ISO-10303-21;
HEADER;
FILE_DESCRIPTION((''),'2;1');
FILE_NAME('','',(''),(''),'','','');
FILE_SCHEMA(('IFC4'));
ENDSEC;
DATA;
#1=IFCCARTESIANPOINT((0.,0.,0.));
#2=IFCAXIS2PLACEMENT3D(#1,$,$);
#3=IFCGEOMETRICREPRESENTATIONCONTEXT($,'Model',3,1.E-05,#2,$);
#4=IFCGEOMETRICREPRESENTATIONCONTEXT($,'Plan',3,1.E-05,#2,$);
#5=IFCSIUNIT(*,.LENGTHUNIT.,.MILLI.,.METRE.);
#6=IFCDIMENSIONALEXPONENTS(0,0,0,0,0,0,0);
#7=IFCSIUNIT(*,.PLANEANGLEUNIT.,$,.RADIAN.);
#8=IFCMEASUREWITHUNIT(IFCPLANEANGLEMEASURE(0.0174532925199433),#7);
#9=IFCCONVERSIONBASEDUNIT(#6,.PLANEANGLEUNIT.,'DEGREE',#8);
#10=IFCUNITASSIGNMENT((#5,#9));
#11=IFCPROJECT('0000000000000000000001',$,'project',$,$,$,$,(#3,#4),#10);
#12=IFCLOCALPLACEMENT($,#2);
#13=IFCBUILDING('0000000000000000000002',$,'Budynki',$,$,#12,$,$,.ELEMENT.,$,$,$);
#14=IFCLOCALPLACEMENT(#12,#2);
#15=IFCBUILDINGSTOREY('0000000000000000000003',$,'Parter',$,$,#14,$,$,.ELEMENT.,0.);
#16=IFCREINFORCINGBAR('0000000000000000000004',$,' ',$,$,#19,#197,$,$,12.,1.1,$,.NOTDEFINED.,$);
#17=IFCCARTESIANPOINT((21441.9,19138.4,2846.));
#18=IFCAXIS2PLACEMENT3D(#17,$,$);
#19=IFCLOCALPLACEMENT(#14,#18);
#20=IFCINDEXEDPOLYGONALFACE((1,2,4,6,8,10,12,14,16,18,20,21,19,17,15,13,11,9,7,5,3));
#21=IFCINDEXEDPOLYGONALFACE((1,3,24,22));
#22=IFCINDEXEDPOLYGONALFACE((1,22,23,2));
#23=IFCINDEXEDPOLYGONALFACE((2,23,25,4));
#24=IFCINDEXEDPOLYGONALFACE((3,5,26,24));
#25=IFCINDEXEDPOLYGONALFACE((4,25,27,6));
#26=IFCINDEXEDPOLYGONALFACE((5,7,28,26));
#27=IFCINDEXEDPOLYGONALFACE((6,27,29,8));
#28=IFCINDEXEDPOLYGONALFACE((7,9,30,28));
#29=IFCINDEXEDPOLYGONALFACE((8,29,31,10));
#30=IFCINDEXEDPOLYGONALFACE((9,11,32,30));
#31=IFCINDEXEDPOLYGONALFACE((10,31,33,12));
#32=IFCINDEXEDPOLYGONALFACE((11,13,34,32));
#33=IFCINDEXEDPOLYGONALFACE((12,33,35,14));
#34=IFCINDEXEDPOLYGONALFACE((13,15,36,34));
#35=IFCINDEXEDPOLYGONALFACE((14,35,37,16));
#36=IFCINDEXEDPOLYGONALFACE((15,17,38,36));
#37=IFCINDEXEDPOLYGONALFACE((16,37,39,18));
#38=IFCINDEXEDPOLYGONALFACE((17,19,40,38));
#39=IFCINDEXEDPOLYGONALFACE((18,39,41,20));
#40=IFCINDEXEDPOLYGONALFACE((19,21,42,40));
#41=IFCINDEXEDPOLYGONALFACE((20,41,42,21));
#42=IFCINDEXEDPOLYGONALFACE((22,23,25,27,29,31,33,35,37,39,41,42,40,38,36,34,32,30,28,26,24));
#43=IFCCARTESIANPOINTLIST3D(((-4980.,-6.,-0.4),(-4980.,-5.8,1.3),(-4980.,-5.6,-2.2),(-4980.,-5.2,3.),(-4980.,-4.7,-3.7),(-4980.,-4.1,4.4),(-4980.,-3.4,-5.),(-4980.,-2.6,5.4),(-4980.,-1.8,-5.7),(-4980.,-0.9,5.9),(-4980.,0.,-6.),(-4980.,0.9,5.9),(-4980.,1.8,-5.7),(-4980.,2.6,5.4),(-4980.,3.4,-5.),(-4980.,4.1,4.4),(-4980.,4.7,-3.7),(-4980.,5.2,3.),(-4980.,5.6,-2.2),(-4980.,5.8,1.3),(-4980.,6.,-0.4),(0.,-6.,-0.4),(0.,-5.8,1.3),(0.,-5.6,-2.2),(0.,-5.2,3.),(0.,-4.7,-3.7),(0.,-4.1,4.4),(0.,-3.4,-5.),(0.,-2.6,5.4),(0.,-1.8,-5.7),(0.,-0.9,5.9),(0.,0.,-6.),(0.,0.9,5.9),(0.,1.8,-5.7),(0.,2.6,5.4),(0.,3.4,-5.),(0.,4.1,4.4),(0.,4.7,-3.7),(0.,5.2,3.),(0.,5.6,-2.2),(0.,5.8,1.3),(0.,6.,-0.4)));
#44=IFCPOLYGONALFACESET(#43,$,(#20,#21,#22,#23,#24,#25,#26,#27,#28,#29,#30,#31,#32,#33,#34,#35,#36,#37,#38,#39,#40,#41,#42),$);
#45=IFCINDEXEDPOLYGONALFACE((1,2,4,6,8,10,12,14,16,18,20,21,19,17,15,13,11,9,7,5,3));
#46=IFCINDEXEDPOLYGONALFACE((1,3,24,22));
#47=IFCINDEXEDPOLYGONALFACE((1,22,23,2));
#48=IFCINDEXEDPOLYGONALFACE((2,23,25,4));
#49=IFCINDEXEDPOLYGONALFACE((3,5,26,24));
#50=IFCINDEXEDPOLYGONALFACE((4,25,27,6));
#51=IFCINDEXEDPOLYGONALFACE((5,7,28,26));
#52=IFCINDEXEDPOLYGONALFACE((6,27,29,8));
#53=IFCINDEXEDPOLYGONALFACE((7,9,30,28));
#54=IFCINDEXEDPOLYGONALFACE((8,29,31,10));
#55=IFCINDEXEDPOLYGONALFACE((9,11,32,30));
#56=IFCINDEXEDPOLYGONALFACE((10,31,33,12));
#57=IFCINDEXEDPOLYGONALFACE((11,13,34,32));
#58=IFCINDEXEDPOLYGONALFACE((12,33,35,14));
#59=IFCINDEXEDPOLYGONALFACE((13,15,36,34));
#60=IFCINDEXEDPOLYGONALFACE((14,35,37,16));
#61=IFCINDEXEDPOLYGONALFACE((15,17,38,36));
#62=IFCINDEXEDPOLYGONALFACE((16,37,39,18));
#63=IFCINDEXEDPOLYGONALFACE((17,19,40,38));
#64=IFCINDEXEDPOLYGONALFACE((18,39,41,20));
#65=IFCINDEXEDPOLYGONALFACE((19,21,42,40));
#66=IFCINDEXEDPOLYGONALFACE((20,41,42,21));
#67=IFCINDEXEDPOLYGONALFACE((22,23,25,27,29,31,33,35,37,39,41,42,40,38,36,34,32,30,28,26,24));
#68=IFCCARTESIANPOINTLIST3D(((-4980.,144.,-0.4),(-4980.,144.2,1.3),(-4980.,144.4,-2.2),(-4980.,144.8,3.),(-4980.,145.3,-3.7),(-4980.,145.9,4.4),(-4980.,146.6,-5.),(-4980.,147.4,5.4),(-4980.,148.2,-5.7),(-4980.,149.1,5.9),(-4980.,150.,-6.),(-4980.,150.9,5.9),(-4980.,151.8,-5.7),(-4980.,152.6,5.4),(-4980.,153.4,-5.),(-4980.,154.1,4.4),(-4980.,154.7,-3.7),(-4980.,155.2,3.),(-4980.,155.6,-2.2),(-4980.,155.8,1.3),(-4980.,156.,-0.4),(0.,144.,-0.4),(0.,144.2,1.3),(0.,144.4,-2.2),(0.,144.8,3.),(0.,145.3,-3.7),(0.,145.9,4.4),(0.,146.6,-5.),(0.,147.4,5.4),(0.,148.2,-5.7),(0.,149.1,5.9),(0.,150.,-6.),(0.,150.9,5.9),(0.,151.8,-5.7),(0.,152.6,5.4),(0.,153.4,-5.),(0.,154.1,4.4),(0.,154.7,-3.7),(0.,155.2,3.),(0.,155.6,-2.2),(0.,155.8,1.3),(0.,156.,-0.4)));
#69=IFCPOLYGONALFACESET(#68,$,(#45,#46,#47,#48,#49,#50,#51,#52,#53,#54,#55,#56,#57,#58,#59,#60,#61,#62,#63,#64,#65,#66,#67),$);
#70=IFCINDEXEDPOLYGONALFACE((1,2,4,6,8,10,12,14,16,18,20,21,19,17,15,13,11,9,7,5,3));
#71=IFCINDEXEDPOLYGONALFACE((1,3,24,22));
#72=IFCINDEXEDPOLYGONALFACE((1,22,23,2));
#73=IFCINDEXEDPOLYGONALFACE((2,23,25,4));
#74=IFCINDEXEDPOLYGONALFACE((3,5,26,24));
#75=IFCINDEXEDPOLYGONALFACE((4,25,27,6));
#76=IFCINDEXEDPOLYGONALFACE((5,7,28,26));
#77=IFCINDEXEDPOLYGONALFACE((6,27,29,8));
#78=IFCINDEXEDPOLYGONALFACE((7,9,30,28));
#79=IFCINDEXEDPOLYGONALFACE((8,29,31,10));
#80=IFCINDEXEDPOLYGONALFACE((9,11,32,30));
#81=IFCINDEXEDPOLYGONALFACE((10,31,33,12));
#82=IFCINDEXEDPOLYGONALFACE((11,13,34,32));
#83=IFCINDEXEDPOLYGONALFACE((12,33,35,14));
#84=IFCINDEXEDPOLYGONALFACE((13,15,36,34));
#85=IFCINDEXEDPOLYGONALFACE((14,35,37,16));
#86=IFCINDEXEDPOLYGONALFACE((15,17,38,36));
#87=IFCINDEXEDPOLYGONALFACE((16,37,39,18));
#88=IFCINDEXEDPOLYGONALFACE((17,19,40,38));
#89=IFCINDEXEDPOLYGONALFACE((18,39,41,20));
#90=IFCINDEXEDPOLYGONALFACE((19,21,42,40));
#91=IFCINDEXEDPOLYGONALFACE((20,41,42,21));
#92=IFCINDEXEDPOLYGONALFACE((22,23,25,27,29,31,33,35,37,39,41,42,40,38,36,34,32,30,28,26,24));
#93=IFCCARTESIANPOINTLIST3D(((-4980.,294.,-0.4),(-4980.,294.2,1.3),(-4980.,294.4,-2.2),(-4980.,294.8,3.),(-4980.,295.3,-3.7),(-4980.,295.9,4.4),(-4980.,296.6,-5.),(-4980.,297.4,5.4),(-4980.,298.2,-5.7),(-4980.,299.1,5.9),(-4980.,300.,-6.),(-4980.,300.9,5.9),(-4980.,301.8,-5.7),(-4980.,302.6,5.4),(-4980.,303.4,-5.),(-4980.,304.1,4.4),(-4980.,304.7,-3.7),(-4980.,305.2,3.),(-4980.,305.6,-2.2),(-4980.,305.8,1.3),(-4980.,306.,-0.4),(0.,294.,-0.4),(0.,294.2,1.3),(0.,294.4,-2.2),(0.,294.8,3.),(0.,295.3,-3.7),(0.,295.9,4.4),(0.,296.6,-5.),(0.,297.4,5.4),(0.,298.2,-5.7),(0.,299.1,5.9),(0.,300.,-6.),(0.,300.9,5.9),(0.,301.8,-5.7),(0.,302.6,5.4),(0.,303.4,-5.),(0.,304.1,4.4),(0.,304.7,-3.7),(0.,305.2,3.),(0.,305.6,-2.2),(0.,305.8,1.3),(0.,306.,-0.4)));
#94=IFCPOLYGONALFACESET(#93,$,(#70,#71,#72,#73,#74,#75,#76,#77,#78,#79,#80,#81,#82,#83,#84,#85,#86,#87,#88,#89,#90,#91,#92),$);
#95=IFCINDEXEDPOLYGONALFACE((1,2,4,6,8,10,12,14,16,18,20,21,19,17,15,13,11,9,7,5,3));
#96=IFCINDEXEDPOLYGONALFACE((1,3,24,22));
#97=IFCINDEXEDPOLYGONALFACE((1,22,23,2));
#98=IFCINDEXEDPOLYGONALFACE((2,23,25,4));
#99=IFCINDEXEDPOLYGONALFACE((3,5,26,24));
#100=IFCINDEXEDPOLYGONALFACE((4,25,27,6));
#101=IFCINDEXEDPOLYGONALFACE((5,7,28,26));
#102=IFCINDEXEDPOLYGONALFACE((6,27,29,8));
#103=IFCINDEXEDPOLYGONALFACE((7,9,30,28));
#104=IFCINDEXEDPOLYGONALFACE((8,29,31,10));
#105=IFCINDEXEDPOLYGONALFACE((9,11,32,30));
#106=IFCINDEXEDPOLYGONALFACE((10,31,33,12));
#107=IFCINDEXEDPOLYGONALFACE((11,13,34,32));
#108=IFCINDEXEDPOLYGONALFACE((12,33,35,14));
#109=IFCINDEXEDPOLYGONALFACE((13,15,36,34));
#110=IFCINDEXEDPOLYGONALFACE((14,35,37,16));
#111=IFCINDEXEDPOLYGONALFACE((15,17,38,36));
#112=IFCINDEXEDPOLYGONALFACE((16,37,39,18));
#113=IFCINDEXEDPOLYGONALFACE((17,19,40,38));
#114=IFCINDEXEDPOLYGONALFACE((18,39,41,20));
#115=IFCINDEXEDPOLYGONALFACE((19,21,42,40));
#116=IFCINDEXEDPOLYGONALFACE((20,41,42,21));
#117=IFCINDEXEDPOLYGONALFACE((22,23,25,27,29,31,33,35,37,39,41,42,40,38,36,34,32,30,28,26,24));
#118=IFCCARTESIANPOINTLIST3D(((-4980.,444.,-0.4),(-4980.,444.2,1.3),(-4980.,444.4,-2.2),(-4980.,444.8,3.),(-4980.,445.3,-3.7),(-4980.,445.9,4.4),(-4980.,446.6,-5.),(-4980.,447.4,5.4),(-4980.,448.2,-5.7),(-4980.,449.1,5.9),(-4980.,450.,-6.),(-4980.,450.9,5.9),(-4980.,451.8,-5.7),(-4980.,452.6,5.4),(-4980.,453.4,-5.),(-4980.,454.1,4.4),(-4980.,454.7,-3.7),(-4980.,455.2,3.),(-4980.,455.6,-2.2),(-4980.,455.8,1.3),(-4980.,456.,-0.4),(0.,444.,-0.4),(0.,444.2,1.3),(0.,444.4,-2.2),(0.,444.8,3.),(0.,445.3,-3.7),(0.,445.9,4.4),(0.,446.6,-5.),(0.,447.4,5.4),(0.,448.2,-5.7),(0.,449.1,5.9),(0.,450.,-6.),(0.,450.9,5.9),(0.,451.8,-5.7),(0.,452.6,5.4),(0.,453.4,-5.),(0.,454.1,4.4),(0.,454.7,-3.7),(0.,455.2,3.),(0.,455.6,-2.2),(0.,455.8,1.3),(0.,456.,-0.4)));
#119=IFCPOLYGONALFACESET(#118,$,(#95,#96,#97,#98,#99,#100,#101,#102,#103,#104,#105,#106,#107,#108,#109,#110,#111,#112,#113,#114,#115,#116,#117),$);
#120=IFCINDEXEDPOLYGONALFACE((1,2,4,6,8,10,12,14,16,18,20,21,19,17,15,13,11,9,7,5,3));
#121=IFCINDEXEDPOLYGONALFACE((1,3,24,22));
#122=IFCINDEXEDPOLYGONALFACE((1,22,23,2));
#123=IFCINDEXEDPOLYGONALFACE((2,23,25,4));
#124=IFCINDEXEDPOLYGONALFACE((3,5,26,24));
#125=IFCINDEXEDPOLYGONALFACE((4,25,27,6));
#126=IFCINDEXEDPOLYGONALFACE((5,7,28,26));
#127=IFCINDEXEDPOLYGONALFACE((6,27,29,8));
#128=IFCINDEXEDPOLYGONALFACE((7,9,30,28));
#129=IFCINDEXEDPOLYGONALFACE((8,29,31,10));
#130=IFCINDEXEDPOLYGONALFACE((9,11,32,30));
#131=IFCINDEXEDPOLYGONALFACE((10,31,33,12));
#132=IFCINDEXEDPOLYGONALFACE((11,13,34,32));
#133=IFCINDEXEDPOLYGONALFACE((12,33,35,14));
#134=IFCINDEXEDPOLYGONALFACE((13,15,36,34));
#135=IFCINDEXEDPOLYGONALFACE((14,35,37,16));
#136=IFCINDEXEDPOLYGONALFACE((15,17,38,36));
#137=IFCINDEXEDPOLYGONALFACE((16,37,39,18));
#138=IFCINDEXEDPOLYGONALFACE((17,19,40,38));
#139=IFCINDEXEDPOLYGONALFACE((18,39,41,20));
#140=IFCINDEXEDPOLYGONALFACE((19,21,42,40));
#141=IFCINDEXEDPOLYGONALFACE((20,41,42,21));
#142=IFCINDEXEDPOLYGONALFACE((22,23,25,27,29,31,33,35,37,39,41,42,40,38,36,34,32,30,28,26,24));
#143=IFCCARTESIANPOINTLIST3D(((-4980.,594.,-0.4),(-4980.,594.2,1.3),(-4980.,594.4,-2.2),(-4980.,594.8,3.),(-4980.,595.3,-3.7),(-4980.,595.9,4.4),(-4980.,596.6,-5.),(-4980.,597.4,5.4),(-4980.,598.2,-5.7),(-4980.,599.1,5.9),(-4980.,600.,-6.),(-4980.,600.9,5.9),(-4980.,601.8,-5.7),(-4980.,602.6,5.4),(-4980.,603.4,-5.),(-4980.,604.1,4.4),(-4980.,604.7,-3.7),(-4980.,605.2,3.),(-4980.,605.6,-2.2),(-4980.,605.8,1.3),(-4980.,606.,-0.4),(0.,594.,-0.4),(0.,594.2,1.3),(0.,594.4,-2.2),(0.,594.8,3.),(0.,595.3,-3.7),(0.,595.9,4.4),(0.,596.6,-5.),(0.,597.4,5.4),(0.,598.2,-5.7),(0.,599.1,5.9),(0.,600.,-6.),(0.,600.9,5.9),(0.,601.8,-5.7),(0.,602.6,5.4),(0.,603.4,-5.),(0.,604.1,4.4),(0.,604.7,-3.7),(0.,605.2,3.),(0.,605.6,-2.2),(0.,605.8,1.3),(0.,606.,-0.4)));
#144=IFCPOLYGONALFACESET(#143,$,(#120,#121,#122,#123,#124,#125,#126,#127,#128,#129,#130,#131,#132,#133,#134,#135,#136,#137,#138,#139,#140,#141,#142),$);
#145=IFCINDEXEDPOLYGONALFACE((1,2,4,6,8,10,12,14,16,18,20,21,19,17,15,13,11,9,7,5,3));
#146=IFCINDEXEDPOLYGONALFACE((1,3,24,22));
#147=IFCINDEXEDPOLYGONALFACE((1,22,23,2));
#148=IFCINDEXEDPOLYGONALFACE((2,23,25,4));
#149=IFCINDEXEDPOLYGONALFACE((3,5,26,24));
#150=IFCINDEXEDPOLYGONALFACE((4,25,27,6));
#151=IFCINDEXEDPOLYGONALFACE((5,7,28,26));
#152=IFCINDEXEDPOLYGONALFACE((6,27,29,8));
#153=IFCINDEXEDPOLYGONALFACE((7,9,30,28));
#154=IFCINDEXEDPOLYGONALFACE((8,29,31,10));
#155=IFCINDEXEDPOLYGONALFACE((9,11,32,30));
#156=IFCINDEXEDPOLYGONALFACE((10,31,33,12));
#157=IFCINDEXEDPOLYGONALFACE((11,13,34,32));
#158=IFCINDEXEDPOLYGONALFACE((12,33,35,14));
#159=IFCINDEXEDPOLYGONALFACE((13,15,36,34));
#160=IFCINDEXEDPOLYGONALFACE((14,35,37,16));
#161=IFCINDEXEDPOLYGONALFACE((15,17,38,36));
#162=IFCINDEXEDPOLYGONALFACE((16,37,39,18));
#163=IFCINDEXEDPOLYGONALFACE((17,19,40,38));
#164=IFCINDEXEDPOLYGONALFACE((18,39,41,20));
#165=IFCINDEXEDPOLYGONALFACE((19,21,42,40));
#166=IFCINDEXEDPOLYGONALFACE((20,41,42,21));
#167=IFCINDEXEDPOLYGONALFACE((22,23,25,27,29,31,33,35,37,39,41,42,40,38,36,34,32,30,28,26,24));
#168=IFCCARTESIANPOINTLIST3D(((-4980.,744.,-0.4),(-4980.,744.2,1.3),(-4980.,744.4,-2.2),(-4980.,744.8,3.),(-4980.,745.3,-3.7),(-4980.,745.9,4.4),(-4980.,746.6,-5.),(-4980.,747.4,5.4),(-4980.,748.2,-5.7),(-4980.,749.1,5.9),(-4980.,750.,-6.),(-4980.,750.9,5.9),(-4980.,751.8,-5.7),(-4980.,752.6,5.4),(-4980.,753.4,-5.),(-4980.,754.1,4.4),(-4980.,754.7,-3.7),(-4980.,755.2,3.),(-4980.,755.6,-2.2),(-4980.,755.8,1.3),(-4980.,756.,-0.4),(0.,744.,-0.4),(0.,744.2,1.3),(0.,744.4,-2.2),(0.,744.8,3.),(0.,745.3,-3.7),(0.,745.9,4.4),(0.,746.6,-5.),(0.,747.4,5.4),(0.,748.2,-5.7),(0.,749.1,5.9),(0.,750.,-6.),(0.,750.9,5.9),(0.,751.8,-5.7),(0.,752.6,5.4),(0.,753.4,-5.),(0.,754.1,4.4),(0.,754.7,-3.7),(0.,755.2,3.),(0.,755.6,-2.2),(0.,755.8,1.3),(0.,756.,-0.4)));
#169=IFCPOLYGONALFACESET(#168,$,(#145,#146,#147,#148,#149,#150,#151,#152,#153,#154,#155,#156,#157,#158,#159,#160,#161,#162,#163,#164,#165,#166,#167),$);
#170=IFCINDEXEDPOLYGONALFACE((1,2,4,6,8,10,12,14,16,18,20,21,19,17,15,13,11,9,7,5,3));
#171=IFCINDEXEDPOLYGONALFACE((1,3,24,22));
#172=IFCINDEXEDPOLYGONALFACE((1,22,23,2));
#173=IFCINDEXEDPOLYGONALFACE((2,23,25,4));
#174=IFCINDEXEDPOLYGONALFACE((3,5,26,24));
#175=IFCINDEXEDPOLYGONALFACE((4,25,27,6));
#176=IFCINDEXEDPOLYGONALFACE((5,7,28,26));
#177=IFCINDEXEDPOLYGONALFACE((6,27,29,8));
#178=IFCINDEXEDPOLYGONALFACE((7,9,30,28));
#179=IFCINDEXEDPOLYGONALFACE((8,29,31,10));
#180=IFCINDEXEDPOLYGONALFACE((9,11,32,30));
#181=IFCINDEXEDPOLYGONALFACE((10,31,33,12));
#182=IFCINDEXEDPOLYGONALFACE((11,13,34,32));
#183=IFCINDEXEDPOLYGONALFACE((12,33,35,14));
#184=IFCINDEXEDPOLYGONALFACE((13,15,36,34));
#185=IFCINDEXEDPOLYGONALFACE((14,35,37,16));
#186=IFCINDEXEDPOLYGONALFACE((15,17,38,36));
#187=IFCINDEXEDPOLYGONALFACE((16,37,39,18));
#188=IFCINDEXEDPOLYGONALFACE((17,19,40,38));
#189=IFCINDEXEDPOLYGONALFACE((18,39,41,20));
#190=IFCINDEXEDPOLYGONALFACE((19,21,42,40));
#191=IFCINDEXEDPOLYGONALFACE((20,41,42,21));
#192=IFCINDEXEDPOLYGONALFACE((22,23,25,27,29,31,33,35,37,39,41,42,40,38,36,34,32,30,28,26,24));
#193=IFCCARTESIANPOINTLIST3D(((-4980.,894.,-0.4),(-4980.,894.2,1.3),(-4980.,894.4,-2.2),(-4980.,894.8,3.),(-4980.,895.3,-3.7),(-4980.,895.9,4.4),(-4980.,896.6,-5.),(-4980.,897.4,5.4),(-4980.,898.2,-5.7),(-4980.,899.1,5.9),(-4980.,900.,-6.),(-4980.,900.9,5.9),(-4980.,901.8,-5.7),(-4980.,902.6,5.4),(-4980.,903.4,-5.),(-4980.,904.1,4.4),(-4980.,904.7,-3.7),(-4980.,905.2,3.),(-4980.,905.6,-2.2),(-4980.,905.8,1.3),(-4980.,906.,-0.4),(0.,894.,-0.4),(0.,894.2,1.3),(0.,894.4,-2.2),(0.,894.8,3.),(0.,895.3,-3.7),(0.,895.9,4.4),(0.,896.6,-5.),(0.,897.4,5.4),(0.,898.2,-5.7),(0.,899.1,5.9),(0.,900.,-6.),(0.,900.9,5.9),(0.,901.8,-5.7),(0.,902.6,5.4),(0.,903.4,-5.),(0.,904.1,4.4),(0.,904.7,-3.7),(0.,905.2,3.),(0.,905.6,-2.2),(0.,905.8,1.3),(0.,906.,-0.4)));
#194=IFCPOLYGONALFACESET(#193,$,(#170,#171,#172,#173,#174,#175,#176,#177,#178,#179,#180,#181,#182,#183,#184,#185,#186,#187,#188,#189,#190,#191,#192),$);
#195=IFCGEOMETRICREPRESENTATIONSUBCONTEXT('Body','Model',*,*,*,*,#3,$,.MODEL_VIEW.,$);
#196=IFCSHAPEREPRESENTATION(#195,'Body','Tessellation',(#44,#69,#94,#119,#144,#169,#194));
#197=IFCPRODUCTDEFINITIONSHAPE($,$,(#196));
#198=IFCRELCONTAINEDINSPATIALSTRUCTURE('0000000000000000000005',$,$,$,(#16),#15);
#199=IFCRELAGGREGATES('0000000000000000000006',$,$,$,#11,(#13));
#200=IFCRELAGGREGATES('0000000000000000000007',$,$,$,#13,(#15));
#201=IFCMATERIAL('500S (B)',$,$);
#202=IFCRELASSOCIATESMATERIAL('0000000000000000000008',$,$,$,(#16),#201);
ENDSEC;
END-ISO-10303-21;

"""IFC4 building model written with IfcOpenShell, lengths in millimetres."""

from ifc_helpers import new_model, entity, si_unit, converted_unit, frame, origin, place, context, subcontext, project, spatial, material, element, save


model = new_model("IFC4")

# Units and contexts
model_context = context("Model", 3, precision=1e-05, world=origin())
plan_context = context("Plan", 3, precision=1e-05, world=origin())
body_context = subcontext(model_context, "Body", "Model", "MODEL_VIEW")
ifc_project = project(units=[si_unit("LENGTHUNIT", "METRE", prefix="MILLI"), converted_unit("PLANEANGLEUNIT", "DEGREE", entity("IfcPlaneAngleMeasure", 0.0174532925199433), si_unit("PLANEANGLEUNIT", "RADIAN"), dimensions=[0, 0, 0, 0, 0, 0, 0])], contexts=[model_context, plan_context])

# Building, storey
building_placement = place(None, origin())
building = spatial("IfcBuilding", under=ifc_project, at=building_placement, Name="Budynki", CompositionType="ELEMENT")
storey_placement = place(building_placement, origin())
storey = spatial("IfcBuildingStorey", under=building, at=storey_placement, Name="Parter", CompositionType="ELEMENT", Elevation=0.0)

# Reinforcing bar
ifc_material_1 = material(Name="500S (B)")
reinforcing_bar_1_placement = place(storey_placement, frame((21441.9, 19138.4, 2846.0)))
element("IfcReinforcingBar", 1, at=reinforcing_bar_1_placement, inside=storey, material=ifc_material_1, Name=" ", CrossSectionArea=1.1, NominalDiameter=12.0, PredefinedType="NOTDEFINED", context=body_context, shape_type="AdvancedSweptSolid", body=[
    entity("IfcSweptDiskSolid", entity("IfcPolyline", [entity("IfcCartesianPoint", [0.0, 0.0, 0.0]), entity("IfcCartesianPoint", [-4980.0, 0.0, 0.0])]), 6.0, None, 0.0, 1.0),
    entity("IfcSweptDiskSolid", entity("IfcPolyline", [entity("IfcCartesianPoint", [0.0, 150.0, 0.0]), entity("IfcCartesianPoint", [-4980.0, 150.0, 0.0])]), 6.0, None, 0.0, 1.0),
    entity("IfcSweptDiskSolid", entity("IfcPolyline", [entity("IfcCartesianPoint", [0.0, 300.0, 0.0]), entity("IfcCartesianPoint", [-4980.0, 300.0, 0.0])]), 6.0, None, 0.0, 1.0),
    entity("IfcSweptDiskSolid", entity("IfcPolyline", [entity("IfcCartesianPoint", [0.0, 450.0, 0.0]), entity("IfcCartesianPoint", [-4980.0, 450.0, 0.0])]), 6.0, None, 0.0, 1.0),
    entity("IfcSweptDiskSolid", entity("IfcPolyline", [entity("IfcCartesianPoint", [0.0, 600.0, 0.0]), entity("IfcCartesianPoint", [-4980.0, 600.0, 0.0])]), 6.0, None, 0.0, 1.0),
    entity("IfcSweptDiskSolid", entity("IfcPolyline", [entity("IfcCartesianPoint", [0.0, 750.0, 0.0]), entity("IfcCartesianPoint", [-4980.0, 750.0, 0.0])]), 6.0, None, 0.0, 1.0),
    entity("IfcSweptDiskSolid", entity("IfcPolyline", [entity("IfcCartesianPoint", [0.0, 900.0, 0.0]), entity("IfcCartesianPoint", [-4980.0, 900.0, 0.0])]), 6.0, None, 0.0, 1.0),
])

save(model, "model.ifc")
